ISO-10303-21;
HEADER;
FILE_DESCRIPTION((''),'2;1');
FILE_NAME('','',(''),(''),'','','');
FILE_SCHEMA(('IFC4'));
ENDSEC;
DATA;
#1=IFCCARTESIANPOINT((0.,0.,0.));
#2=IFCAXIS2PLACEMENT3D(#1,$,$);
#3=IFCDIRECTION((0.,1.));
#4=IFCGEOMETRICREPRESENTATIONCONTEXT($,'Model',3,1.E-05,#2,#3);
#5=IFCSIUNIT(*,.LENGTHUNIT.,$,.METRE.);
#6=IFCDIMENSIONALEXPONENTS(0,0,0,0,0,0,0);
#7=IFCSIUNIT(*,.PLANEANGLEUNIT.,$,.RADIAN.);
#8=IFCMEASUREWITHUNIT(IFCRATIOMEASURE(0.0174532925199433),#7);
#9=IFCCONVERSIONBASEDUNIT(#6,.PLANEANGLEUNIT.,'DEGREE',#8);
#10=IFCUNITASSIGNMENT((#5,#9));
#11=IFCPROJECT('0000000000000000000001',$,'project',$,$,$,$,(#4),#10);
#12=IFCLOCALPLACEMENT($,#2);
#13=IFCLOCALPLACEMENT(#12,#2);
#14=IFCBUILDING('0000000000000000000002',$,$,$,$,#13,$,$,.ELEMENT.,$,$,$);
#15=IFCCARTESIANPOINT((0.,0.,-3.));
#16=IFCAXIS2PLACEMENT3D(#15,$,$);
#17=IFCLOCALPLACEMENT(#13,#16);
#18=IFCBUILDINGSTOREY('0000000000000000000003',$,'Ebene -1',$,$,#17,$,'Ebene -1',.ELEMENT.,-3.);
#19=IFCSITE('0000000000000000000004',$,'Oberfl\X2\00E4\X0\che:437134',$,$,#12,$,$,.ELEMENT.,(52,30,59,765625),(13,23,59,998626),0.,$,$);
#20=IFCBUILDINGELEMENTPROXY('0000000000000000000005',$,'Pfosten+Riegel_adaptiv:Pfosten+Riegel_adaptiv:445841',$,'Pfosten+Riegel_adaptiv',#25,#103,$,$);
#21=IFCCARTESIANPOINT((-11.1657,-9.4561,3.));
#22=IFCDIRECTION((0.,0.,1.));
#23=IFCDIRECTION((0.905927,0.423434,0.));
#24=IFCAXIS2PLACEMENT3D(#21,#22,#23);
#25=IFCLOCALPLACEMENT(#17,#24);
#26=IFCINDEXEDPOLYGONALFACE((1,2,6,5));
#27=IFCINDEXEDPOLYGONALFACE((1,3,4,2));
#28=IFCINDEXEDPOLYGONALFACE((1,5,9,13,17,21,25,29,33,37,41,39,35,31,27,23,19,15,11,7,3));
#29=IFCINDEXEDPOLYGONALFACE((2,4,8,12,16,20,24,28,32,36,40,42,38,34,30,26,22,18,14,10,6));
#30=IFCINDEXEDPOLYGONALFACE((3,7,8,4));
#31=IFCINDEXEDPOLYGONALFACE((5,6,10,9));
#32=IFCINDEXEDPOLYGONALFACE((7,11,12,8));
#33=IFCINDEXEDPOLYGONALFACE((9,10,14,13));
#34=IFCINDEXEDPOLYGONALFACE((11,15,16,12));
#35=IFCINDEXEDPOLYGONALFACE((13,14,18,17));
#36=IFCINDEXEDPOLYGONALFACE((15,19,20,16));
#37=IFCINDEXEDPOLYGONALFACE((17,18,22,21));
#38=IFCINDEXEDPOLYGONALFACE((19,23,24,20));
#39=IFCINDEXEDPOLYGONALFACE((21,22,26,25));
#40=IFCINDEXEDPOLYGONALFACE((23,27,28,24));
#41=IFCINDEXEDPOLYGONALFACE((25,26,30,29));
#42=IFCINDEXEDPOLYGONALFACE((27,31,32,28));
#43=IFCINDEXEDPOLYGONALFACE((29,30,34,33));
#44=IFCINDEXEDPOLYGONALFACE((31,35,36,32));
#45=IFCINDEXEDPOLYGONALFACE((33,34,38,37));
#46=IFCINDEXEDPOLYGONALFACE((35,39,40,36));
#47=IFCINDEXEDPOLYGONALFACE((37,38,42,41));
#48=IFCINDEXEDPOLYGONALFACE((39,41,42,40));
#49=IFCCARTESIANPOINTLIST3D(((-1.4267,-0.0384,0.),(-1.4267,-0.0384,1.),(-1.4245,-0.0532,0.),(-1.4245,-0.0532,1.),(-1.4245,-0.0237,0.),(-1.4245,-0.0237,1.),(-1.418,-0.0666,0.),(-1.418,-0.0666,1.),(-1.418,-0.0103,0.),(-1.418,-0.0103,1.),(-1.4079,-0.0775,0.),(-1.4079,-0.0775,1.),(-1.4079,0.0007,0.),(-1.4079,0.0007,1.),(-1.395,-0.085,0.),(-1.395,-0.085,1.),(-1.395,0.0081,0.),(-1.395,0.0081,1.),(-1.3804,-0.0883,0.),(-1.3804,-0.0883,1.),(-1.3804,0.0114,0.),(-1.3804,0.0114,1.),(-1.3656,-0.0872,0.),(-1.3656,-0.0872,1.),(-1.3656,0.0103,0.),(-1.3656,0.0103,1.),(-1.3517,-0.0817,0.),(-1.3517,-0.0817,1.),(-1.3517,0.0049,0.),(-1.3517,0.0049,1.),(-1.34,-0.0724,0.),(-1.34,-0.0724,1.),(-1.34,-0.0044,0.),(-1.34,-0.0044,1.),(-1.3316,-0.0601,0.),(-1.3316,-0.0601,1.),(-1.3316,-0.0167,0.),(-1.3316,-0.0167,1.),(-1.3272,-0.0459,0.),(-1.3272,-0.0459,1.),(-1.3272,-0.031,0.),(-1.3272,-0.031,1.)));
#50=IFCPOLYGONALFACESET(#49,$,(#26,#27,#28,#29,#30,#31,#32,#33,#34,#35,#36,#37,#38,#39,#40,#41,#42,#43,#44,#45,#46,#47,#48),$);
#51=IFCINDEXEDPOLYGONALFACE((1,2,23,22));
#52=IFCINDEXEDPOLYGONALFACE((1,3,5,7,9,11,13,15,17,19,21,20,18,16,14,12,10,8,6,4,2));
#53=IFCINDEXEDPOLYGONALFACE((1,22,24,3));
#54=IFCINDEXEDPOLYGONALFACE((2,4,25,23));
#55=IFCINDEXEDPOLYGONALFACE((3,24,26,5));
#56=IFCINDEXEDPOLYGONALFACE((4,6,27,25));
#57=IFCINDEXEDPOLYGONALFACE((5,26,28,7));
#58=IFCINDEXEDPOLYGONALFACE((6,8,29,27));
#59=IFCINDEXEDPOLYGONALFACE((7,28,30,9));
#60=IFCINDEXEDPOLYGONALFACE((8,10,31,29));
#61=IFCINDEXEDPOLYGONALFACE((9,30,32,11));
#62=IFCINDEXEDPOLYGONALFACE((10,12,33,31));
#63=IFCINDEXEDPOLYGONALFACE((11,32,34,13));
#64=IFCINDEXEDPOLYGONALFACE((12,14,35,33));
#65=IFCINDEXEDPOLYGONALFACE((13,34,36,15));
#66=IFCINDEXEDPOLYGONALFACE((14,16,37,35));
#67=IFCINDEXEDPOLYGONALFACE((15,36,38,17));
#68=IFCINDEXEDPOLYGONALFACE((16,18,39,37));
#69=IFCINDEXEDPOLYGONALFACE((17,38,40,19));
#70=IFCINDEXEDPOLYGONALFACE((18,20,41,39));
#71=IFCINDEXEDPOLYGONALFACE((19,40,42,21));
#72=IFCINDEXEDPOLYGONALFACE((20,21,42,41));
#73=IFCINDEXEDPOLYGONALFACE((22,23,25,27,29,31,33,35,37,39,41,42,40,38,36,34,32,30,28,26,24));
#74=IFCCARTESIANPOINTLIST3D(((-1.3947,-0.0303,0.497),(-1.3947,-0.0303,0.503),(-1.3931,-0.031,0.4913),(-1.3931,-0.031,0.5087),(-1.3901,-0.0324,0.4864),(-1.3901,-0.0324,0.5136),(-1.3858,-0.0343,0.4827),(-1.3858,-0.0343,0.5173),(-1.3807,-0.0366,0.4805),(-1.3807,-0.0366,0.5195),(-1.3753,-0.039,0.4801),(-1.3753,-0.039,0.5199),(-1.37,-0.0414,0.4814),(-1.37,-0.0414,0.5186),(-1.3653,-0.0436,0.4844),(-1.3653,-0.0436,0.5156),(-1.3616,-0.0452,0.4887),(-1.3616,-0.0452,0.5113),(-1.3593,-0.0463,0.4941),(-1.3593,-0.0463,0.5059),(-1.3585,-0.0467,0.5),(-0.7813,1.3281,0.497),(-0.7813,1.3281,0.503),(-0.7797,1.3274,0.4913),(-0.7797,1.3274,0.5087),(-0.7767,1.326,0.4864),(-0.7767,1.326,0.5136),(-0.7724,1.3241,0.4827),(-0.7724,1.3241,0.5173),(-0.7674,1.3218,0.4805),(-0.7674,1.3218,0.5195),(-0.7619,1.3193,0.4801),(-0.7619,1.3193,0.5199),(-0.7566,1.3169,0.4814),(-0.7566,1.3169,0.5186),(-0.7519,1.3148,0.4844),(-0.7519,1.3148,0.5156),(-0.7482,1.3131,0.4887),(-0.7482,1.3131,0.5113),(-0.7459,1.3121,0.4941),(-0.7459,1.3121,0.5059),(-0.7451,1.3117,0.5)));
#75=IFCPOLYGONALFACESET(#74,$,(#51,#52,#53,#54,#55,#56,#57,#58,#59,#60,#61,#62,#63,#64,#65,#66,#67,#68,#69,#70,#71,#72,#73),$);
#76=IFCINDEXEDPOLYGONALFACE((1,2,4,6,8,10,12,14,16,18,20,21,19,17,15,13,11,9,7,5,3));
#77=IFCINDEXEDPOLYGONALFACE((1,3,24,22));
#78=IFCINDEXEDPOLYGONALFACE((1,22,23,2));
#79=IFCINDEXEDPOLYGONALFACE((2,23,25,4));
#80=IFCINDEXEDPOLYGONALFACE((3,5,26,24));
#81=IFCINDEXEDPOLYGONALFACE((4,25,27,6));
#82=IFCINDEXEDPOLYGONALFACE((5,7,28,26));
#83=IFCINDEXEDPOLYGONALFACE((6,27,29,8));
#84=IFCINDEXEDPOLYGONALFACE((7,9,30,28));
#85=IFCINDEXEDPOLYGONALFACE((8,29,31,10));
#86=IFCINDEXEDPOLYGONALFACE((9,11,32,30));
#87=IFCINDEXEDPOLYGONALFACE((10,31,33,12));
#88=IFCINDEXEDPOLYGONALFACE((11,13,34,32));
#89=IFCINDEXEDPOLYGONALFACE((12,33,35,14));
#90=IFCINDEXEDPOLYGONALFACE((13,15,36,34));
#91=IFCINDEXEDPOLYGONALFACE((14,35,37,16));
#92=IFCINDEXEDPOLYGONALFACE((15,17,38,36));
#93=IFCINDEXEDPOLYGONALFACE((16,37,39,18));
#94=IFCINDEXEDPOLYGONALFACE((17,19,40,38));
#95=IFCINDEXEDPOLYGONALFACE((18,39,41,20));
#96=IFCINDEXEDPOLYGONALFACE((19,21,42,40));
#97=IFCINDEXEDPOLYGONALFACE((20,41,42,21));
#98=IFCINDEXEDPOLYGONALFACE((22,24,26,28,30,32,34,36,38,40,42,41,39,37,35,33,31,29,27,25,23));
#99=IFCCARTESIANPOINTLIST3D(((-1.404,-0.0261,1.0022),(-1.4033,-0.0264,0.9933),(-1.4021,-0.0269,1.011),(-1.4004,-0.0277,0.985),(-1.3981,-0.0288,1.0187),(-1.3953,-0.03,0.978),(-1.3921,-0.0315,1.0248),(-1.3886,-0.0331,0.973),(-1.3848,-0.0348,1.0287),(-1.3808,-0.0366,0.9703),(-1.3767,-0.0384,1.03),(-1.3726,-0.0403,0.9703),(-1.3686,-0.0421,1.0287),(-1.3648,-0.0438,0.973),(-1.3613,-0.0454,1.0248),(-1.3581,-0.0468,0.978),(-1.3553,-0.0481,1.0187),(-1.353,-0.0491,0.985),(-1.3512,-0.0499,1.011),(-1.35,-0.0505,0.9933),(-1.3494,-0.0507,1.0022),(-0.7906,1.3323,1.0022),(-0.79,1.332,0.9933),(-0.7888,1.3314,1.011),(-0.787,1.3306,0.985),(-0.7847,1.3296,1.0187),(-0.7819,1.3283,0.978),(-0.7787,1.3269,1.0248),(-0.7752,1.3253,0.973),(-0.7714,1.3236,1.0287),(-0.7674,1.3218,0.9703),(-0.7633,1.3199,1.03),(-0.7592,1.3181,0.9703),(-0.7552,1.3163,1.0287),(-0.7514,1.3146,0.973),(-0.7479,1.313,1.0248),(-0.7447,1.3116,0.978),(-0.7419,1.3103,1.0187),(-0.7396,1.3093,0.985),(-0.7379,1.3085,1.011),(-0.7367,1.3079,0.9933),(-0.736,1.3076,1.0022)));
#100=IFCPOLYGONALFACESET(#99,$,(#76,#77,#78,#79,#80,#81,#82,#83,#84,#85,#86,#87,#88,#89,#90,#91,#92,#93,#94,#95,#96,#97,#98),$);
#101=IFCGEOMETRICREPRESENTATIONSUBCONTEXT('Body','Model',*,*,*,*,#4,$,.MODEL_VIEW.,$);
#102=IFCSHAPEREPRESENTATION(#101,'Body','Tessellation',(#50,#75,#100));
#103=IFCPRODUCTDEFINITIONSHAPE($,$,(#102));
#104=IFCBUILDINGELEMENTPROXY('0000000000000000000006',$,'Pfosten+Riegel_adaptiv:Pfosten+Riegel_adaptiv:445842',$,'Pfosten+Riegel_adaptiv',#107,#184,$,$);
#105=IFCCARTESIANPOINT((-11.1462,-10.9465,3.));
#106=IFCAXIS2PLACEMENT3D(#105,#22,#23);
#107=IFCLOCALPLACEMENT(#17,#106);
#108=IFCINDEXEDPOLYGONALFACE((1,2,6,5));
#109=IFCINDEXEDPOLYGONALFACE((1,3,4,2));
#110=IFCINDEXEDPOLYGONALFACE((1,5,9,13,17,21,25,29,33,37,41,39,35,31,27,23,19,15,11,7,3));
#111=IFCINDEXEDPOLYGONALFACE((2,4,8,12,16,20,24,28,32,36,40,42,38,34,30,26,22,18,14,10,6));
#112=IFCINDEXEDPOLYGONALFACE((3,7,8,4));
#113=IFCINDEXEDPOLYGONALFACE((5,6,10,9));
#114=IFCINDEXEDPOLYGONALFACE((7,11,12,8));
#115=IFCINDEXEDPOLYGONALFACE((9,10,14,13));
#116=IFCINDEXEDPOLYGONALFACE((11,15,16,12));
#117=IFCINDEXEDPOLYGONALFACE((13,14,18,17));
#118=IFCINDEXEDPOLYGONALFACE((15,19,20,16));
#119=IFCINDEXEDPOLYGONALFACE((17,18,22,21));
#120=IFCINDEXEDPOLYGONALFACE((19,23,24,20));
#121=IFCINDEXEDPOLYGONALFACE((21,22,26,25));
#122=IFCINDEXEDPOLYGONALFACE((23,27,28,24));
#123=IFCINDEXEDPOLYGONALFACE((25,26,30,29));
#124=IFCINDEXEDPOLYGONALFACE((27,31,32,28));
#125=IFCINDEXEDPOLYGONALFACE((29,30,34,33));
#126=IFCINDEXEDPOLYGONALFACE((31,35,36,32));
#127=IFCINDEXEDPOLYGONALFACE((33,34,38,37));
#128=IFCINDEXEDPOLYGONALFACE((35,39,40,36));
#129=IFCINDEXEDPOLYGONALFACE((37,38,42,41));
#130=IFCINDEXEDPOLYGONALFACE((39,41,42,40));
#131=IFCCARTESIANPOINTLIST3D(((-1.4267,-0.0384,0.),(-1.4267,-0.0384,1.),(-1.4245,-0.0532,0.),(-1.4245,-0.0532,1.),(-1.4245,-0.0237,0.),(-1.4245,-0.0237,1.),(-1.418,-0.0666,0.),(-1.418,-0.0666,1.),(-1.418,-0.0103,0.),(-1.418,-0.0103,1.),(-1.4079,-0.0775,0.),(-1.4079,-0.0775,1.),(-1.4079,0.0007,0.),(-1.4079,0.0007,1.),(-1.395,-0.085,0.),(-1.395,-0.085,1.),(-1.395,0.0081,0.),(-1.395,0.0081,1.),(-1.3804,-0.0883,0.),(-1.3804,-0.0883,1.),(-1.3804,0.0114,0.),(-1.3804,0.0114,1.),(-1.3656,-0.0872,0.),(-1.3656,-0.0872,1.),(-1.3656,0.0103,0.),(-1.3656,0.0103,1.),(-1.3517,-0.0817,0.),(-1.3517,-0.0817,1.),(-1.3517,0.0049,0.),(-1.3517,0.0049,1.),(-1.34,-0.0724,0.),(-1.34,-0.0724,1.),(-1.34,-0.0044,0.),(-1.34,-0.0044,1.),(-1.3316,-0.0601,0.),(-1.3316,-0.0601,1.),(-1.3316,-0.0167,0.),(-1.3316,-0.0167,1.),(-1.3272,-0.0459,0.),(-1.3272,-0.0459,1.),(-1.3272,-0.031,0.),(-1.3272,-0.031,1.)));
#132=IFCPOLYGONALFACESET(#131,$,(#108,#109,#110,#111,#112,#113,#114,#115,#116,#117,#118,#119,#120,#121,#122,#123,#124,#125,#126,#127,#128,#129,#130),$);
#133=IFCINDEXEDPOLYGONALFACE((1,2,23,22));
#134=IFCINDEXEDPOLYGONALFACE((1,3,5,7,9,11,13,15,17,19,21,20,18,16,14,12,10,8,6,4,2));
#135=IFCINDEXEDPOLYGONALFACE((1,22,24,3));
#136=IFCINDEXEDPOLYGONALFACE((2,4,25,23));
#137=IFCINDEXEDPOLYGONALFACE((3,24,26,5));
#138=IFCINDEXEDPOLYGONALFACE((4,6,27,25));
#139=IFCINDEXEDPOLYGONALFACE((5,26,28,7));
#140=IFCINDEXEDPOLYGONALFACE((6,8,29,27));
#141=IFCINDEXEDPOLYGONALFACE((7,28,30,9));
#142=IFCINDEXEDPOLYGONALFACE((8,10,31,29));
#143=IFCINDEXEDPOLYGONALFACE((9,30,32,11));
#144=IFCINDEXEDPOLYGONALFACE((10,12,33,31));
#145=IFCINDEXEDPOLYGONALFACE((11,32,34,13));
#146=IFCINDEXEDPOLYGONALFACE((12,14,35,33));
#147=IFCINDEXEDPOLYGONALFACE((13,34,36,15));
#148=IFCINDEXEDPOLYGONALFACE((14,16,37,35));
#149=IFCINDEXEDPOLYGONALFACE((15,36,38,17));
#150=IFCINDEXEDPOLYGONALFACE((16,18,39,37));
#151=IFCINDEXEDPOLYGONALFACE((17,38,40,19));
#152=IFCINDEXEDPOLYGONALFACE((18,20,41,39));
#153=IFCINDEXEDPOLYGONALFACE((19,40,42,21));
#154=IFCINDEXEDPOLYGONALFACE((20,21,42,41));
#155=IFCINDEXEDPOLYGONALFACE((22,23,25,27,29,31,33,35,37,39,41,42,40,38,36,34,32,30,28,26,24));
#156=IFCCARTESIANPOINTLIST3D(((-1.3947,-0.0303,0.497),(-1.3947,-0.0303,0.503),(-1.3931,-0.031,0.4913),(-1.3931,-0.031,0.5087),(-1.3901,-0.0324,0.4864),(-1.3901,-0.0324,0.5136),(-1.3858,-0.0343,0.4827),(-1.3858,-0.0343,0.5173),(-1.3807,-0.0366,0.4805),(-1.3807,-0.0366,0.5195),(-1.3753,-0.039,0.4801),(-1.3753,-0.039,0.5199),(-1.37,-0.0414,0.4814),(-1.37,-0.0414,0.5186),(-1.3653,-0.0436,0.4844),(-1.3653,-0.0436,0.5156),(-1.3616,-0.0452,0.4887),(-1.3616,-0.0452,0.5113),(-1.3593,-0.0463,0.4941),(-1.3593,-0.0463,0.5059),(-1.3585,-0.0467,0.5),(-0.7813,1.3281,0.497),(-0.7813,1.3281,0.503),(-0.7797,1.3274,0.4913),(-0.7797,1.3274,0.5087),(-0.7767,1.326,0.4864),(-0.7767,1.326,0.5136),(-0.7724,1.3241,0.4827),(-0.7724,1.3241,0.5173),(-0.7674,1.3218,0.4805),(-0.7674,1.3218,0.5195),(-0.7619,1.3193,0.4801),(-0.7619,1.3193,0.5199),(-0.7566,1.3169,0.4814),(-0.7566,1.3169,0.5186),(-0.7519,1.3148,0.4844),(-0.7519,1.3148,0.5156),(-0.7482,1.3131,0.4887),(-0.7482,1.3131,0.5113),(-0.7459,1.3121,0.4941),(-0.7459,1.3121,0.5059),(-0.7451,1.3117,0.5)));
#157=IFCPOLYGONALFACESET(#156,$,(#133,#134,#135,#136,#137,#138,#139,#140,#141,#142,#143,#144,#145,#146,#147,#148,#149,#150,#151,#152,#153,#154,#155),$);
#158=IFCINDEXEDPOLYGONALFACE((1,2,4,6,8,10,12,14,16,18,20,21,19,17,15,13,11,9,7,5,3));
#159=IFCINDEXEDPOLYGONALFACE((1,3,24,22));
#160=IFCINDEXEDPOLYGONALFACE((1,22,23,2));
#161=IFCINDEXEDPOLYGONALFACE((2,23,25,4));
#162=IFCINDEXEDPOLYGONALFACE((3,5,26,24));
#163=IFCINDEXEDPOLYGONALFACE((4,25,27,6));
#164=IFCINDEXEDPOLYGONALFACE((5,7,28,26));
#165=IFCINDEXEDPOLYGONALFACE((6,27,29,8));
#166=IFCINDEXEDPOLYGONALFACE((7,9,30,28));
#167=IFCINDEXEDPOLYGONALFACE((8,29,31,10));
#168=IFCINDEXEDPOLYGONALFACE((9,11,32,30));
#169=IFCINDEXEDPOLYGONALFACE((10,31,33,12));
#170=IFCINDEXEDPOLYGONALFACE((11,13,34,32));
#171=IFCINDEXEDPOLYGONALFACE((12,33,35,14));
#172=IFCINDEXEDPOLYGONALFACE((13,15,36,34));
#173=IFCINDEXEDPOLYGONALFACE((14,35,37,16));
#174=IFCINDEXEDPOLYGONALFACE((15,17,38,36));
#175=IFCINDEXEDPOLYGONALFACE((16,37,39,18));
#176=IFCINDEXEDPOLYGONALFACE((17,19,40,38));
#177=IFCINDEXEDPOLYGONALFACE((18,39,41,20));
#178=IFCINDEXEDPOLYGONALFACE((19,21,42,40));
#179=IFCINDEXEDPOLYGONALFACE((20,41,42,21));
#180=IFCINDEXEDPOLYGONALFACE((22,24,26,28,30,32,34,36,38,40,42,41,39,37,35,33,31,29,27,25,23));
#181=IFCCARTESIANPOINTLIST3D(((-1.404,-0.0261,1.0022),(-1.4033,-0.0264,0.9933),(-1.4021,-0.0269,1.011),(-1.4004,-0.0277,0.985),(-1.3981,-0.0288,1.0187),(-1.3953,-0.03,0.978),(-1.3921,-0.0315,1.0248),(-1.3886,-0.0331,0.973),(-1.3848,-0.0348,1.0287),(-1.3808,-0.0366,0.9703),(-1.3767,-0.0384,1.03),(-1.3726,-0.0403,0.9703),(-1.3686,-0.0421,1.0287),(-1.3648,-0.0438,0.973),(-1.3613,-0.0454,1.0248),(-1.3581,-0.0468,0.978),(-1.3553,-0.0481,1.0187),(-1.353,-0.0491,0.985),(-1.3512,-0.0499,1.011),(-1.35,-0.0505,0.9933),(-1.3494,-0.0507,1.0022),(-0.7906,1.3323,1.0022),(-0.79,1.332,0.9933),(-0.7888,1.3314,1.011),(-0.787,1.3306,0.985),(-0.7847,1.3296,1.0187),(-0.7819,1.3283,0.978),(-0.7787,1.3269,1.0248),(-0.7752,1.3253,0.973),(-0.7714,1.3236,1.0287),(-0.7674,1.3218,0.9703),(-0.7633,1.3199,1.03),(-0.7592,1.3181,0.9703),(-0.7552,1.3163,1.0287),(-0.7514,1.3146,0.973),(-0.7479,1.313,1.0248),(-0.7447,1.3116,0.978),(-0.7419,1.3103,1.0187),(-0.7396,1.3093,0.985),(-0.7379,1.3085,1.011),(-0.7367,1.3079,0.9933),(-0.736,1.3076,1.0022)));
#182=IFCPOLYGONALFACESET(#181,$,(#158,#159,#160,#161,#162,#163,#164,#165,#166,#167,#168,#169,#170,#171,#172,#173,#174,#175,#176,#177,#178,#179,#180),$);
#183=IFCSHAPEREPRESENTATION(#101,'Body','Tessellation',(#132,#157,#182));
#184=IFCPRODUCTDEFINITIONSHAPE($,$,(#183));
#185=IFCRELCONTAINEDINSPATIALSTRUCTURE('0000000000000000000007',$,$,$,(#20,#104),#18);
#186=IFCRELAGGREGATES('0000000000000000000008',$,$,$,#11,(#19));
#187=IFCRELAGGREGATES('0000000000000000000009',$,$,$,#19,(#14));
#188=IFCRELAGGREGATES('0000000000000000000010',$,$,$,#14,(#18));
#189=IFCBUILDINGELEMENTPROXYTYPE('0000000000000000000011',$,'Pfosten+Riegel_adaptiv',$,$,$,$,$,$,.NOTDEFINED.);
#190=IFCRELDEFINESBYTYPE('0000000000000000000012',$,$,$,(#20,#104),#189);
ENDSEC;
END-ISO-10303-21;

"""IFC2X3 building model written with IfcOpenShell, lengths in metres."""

from ifc_helpers import new_model, entity, si_unit, converted_unit, direction, frame, frame_2d, origin, place, context, subcontext, project, spatial, circle, extrude, source, transform, mapped, type_object, type_shapes, element, save


model = new_model("IFC2X3")

# Units and contexts
model_context = context("Model", 3, precision=1e-05, world=origin(), true_north=direction((0.0, 1.0)))
body_context = subcontext(model_context, "Body", "Model", "MODEL_VIEW")
ifc_project = project(units=[si_unit("LENGTHUNIT", "METRE"), converted_unit("PLANEANGLEUNIT", "DEGREE", entity("IfcRatioMeasure", 0.0174532925199433), si_unit("PLANEANGLEUNIT", "RADIAN"), dimensions=[0, 0, 0, 0, 0, 0, 0])], contexts=[model_context])

# Site, building, storey
site_placement = place(None, origin())
site = spatial("IfcSite", under=ifc_project, at=site_placement, Name="Oberfläche:437134", CompositionType="ELEMENT", RefLatitude=(52, 30, 59, 765625), RefLongitude=(13, 23, 59, 998626), RefElevation=0.0)
building_placement = place(site_placement, origin())
building = spatial("IfcBuilding", under=site, at=building_placement, CompositionType="ELEMENT")
storey_placement = place(building_placement, frame((0.0, 0.0, -3.0)))
storey = spatial("IfcBuildingStorey", under=building, at=storey_placement, Name="Ebene -1", LongName="Ebene -1", CompositionType="ELEMENT", Elevation=-3.0)

# Building element proxies
building_element_proxy_type_1 = type_object("IfcBuildingElementProxyType", Name="Pfosten+Riegel_adaptiv", PredefinedType="NOTDEFINED")
shared_shape_1 = source(origin(), body_context, "Body", "SweptSolid", [
    extrude(circle(Radius=0.05, at=frame_2d((0.0, 0.0), x_axis=(1.0, 0.0))), frame((-1.3767, -0.0384, 0.0), z_axis=(0.0, 0.0, 1.0), x_axis=(-1.0, 0.0, 0.0)), (0.0, 0.0, 1.0), 1.0),
    extrude(circle(Radius=0.02, at=frame_2d((0.0, 0.0), x_axis=(1.0, 0.0))), frame((-1.3767, -0.0384, 0.5), z_axis=(0.411546, 0.911389, 0.0), x_axis=(0.911389, -0.411546, 0.0)), (0.0, 0.0, 1.0), 1.4904),
    extrude(circle(Radius=0.03, at=frame_2d((0.0, 0.0), x_axis=(1.0, 0.0))), frame((-1.3767, -0.0384, 1.0), z_axis=(0.411546, 0.911389, 0.0), x_axis=(0.0, 0.0, 1.0)), (0.0, 0.0, 1.0), 1.4904),
])
type_shapes(building_element_proxy_type_1, [shared_shape_1])
for number, where, z_axis, x_axis, name in (
    (1, (-11.1657, -9.4561, 3.0), (0.0, 0.0, 1.0), (0.905927, 0.423434, 0.0), "Pfosten+Riegel_adaptiv:Pfosten+Riegel_adaptiv:445841"),
    (2, (-11.1462, -10.9465, 3.0), (0.0, 0.0, 1.0), (0.905927, 0.423434, 0.0), "Pfosten+Riegel_adaptiv:Pfosten+Riegel_adaptiv:445842"),
):
    element("IfcBuildingElementProxy", number, at=place(storey_placement, frame(where, z_axis=z_axis, x_axis=x_axis)), inside=storey, type_object=building_element_proxy_type_1, Name=name, ObjectType="Pfosten+Riegel_adaptiv", context=body_context, shape_type="MappedRepresentation", body=[
        mapped(shared_shape_1, transform((0.0, 0.0, 0.0), scale=1.0)),
    ])

save(model, "model.ifc")
